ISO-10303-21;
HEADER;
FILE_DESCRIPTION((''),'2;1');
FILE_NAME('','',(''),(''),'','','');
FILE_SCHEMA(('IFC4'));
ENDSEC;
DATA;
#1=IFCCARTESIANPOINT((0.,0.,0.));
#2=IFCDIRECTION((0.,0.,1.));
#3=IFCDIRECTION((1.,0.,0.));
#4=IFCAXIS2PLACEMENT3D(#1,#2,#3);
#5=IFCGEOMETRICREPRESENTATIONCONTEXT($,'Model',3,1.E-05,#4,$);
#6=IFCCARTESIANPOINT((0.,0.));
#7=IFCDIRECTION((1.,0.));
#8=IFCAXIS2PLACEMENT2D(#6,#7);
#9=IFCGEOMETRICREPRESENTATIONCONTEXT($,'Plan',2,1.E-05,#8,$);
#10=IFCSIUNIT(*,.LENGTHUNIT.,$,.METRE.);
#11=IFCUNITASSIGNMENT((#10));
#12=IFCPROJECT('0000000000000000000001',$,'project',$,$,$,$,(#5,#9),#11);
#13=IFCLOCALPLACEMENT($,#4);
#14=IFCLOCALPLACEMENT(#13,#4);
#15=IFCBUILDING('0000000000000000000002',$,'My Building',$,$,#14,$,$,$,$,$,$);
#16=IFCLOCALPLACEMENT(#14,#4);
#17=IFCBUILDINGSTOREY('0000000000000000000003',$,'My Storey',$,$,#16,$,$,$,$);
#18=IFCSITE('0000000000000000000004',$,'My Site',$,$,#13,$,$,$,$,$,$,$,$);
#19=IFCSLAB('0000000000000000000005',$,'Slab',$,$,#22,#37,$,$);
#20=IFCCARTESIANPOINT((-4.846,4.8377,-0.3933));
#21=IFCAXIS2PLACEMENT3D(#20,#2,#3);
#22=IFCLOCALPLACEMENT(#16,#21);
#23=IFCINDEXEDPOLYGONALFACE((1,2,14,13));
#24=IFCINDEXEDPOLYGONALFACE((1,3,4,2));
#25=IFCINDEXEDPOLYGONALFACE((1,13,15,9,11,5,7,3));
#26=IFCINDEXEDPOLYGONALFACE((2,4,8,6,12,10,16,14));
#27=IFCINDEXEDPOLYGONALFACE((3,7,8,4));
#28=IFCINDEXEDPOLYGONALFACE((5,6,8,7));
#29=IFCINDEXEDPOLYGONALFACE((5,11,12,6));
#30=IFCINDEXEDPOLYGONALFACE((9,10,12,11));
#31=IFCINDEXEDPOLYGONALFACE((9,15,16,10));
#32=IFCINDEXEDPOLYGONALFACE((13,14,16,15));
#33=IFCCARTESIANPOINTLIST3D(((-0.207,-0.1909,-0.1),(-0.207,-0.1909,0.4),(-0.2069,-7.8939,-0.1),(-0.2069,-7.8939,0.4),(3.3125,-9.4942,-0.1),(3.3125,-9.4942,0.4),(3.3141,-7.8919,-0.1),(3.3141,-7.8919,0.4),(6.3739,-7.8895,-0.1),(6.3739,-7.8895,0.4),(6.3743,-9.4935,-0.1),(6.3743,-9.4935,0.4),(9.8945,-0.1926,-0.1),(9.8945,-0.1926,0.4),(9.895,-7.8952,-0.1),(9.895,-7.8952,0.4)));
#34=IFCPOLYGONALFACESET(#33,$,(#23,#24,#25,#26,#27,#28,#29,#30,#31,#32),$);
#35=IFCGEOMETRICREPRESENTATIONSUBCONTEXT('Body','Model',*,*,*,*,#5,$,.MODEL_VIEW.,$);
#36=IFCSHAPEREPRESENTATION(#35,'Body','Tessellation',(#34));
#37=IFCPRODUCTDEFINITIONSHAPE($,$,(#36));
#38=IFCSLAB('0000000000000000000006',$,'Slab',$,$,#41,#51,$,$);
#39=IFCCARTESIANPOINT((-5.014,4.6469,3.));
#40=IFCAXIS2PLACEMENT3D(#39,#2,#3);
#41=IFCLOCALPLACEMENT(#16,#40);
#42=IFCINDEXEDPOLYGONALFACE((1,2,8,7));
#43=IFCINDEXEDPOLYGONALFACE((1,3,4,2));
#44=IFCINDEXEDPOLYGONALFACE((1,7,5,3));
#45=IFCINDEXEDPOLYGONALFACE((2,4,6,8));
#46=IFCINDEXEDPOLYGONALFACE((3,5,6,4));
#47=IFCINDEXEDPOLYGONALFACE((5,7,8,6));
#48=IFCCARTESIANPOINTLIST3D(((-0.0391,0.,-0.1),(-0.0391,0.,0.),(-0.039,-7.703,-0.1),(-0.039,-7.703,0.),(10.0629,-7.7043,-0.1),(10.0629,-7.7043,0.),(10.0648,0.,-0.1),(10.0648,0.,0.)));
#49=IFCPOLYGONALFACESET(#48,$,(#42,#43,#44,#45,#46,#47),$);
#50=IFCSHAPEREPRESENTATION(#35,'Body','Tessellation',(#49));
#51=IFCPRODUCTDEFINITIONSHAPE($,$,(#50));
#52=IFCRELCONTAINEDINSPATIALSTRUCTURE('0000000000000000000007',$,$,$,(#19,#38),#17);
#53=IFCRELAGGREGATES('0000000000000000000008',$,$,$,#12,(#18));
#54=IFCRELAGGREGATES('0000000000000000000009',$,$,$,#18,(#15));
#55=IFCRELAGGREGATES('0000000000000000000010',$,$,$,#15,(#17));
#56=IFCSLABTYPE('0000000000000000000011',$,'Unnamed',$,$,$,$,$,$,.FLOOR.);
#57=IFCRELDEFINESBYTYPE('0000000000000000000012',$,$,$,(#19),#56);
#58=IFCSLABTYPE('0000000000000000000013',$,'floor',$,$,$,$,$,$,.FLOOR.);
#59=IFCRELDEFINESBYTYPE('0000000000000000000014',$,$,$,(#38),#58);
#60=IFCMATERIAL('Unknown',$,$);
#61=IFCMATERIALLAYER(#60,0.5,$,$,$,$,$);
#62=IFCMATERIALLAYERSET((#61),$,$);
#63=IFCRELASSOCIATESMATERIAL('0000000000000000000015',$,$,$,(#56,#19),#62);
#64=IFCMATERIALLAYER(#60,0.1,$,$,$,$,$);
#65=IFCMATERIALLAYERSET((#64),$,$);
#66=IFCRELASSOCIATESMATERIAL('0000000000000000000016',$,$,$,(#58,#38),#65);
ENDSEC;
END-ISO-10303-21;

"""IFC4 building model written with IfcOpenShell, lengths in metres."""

from ifc_helpers import new_model, si_unit, frame, origin_with_axes, origin_2d_with_axis, place, context, subcontext, project, spatial, indexed_curve, outline, extrude, material, layer, layer_set, layer_usage, type_object, element, save


model = new_model("IFC4")

# Units and contexts
model_context = context("Model", 3, precision=1e-05, world=origin_with_axes())
plan_context = context("Plan", 2, precision=1e-05, world=origin_2d_with_axis())
body_context_1 = subcontext(model_context, "Body", "Model", "MODEL_VIEW")
ifc_project = project(units=[si_unit("LENGTHUNIT", "METRE")], contexts=[model_context, plan_context])

# Site, building, storey
site_placement = place(None, origin_with_axes())
site = spatial("IfcSite", under=ifc_project, at=site_placement, Name="My Site")
building_placement = place(site_placement, origin_with_axes())
building = spatial("IfcBuilding", under=site, at=building_placement, Name="My Building")
storey_placement = place(building_placement, origin_with_axes())
storey = spatial("IfcBuildingStorey", under=building, at=storey_placement, Name="My Storey")

# Shared definitions
ifc_material = material(Name="Unknown")

# Slabs
ifc_layer_1 = layer(ifc_material, 0.5)
ifc_layer_set_1 = layer_set([ifc_layer_1])
ifc_layer_usage_1 = layer_usage(ifc_layer_set_1, "AXIS3", "POSITIVE", -0.1)
slab_type_1 = type_object("IfcSlabType", Name="Unnamed", PredefinedType="FLOOR", material=ifc_layer_set_1)
slab_1_placement = place(storey_placement, frame((-4.846, 4.8377, -0.3933), z_axis=(0.0, 0.0, 1.0), x_axis=(1.0, 0.0, 0.0)))
element("IfcSlab", 1, at=slab_1_placement, inside=storey, type_object=slab_type_1, material=ifc_layer_usage_1, Name="Slab", context=body_context_1, shape_type="SweptSolid", body=[
    extrude(outline(indexed_curve([(9.8945, -0.1926), (9.895, -7.8952), (6.3739, -7.8895), (6.3743, -9.4935), (3.3125, -9.4942), (3.3141, -7.8919), (-0.2069, -7.8939), (-0.207, -0.1909), (9.8945, -0.1926)])), frame((0.0, 0.0, -0.1), z_axis=(0.0, 0.0, 1.0), x_axis=(1.0, 0.0, 0.0)), (0.0, 0.0, 1.0), 0.5),
])
ifc_layer_2 = layer(ifc_material, 0.1)
ifc_layer_set_2 = layer_set([ifc_layer_2])
ifc_layer_usage_2 = layer_usage(ifc_layer_set_2, "AXIS3", "POSITIVE", -0.1)
slab_type_2 = type_object("IfcSlabType", Name="floor", PredefinedType="FLOOR", material=ifc_layer_set_2)
slab_2_placement = place(storey_placement, frame((-5.014, 4.6469, 3.0), z_axis=(0.0, 0.0, 1.0), x_axis=(1.0, 0.0, 0.0)))
element("IfcSlab", 2, at=slab_2_placement, inside=storey, type_object=slab_type_2, material=ifc_layer_usage_2, Name="Slab", context=body_context_1, shape_type="SweptSolid", body=[
    extrude(outline(indexed_curve([(10.0648, 0.0), (10.0629, -7.7043), (-0.039, -7.703), (-0.0391, 0.0), (10.0648, 0.0)])), frame((0.0, 0.0, -0.1), z_axis=(0.0, 0.0, 1.0), x_axis=(1.0, 0.0, 0.0)), (0.0, 0.0, 1.0), 0.1),
])

save(model, "model.ifc")
